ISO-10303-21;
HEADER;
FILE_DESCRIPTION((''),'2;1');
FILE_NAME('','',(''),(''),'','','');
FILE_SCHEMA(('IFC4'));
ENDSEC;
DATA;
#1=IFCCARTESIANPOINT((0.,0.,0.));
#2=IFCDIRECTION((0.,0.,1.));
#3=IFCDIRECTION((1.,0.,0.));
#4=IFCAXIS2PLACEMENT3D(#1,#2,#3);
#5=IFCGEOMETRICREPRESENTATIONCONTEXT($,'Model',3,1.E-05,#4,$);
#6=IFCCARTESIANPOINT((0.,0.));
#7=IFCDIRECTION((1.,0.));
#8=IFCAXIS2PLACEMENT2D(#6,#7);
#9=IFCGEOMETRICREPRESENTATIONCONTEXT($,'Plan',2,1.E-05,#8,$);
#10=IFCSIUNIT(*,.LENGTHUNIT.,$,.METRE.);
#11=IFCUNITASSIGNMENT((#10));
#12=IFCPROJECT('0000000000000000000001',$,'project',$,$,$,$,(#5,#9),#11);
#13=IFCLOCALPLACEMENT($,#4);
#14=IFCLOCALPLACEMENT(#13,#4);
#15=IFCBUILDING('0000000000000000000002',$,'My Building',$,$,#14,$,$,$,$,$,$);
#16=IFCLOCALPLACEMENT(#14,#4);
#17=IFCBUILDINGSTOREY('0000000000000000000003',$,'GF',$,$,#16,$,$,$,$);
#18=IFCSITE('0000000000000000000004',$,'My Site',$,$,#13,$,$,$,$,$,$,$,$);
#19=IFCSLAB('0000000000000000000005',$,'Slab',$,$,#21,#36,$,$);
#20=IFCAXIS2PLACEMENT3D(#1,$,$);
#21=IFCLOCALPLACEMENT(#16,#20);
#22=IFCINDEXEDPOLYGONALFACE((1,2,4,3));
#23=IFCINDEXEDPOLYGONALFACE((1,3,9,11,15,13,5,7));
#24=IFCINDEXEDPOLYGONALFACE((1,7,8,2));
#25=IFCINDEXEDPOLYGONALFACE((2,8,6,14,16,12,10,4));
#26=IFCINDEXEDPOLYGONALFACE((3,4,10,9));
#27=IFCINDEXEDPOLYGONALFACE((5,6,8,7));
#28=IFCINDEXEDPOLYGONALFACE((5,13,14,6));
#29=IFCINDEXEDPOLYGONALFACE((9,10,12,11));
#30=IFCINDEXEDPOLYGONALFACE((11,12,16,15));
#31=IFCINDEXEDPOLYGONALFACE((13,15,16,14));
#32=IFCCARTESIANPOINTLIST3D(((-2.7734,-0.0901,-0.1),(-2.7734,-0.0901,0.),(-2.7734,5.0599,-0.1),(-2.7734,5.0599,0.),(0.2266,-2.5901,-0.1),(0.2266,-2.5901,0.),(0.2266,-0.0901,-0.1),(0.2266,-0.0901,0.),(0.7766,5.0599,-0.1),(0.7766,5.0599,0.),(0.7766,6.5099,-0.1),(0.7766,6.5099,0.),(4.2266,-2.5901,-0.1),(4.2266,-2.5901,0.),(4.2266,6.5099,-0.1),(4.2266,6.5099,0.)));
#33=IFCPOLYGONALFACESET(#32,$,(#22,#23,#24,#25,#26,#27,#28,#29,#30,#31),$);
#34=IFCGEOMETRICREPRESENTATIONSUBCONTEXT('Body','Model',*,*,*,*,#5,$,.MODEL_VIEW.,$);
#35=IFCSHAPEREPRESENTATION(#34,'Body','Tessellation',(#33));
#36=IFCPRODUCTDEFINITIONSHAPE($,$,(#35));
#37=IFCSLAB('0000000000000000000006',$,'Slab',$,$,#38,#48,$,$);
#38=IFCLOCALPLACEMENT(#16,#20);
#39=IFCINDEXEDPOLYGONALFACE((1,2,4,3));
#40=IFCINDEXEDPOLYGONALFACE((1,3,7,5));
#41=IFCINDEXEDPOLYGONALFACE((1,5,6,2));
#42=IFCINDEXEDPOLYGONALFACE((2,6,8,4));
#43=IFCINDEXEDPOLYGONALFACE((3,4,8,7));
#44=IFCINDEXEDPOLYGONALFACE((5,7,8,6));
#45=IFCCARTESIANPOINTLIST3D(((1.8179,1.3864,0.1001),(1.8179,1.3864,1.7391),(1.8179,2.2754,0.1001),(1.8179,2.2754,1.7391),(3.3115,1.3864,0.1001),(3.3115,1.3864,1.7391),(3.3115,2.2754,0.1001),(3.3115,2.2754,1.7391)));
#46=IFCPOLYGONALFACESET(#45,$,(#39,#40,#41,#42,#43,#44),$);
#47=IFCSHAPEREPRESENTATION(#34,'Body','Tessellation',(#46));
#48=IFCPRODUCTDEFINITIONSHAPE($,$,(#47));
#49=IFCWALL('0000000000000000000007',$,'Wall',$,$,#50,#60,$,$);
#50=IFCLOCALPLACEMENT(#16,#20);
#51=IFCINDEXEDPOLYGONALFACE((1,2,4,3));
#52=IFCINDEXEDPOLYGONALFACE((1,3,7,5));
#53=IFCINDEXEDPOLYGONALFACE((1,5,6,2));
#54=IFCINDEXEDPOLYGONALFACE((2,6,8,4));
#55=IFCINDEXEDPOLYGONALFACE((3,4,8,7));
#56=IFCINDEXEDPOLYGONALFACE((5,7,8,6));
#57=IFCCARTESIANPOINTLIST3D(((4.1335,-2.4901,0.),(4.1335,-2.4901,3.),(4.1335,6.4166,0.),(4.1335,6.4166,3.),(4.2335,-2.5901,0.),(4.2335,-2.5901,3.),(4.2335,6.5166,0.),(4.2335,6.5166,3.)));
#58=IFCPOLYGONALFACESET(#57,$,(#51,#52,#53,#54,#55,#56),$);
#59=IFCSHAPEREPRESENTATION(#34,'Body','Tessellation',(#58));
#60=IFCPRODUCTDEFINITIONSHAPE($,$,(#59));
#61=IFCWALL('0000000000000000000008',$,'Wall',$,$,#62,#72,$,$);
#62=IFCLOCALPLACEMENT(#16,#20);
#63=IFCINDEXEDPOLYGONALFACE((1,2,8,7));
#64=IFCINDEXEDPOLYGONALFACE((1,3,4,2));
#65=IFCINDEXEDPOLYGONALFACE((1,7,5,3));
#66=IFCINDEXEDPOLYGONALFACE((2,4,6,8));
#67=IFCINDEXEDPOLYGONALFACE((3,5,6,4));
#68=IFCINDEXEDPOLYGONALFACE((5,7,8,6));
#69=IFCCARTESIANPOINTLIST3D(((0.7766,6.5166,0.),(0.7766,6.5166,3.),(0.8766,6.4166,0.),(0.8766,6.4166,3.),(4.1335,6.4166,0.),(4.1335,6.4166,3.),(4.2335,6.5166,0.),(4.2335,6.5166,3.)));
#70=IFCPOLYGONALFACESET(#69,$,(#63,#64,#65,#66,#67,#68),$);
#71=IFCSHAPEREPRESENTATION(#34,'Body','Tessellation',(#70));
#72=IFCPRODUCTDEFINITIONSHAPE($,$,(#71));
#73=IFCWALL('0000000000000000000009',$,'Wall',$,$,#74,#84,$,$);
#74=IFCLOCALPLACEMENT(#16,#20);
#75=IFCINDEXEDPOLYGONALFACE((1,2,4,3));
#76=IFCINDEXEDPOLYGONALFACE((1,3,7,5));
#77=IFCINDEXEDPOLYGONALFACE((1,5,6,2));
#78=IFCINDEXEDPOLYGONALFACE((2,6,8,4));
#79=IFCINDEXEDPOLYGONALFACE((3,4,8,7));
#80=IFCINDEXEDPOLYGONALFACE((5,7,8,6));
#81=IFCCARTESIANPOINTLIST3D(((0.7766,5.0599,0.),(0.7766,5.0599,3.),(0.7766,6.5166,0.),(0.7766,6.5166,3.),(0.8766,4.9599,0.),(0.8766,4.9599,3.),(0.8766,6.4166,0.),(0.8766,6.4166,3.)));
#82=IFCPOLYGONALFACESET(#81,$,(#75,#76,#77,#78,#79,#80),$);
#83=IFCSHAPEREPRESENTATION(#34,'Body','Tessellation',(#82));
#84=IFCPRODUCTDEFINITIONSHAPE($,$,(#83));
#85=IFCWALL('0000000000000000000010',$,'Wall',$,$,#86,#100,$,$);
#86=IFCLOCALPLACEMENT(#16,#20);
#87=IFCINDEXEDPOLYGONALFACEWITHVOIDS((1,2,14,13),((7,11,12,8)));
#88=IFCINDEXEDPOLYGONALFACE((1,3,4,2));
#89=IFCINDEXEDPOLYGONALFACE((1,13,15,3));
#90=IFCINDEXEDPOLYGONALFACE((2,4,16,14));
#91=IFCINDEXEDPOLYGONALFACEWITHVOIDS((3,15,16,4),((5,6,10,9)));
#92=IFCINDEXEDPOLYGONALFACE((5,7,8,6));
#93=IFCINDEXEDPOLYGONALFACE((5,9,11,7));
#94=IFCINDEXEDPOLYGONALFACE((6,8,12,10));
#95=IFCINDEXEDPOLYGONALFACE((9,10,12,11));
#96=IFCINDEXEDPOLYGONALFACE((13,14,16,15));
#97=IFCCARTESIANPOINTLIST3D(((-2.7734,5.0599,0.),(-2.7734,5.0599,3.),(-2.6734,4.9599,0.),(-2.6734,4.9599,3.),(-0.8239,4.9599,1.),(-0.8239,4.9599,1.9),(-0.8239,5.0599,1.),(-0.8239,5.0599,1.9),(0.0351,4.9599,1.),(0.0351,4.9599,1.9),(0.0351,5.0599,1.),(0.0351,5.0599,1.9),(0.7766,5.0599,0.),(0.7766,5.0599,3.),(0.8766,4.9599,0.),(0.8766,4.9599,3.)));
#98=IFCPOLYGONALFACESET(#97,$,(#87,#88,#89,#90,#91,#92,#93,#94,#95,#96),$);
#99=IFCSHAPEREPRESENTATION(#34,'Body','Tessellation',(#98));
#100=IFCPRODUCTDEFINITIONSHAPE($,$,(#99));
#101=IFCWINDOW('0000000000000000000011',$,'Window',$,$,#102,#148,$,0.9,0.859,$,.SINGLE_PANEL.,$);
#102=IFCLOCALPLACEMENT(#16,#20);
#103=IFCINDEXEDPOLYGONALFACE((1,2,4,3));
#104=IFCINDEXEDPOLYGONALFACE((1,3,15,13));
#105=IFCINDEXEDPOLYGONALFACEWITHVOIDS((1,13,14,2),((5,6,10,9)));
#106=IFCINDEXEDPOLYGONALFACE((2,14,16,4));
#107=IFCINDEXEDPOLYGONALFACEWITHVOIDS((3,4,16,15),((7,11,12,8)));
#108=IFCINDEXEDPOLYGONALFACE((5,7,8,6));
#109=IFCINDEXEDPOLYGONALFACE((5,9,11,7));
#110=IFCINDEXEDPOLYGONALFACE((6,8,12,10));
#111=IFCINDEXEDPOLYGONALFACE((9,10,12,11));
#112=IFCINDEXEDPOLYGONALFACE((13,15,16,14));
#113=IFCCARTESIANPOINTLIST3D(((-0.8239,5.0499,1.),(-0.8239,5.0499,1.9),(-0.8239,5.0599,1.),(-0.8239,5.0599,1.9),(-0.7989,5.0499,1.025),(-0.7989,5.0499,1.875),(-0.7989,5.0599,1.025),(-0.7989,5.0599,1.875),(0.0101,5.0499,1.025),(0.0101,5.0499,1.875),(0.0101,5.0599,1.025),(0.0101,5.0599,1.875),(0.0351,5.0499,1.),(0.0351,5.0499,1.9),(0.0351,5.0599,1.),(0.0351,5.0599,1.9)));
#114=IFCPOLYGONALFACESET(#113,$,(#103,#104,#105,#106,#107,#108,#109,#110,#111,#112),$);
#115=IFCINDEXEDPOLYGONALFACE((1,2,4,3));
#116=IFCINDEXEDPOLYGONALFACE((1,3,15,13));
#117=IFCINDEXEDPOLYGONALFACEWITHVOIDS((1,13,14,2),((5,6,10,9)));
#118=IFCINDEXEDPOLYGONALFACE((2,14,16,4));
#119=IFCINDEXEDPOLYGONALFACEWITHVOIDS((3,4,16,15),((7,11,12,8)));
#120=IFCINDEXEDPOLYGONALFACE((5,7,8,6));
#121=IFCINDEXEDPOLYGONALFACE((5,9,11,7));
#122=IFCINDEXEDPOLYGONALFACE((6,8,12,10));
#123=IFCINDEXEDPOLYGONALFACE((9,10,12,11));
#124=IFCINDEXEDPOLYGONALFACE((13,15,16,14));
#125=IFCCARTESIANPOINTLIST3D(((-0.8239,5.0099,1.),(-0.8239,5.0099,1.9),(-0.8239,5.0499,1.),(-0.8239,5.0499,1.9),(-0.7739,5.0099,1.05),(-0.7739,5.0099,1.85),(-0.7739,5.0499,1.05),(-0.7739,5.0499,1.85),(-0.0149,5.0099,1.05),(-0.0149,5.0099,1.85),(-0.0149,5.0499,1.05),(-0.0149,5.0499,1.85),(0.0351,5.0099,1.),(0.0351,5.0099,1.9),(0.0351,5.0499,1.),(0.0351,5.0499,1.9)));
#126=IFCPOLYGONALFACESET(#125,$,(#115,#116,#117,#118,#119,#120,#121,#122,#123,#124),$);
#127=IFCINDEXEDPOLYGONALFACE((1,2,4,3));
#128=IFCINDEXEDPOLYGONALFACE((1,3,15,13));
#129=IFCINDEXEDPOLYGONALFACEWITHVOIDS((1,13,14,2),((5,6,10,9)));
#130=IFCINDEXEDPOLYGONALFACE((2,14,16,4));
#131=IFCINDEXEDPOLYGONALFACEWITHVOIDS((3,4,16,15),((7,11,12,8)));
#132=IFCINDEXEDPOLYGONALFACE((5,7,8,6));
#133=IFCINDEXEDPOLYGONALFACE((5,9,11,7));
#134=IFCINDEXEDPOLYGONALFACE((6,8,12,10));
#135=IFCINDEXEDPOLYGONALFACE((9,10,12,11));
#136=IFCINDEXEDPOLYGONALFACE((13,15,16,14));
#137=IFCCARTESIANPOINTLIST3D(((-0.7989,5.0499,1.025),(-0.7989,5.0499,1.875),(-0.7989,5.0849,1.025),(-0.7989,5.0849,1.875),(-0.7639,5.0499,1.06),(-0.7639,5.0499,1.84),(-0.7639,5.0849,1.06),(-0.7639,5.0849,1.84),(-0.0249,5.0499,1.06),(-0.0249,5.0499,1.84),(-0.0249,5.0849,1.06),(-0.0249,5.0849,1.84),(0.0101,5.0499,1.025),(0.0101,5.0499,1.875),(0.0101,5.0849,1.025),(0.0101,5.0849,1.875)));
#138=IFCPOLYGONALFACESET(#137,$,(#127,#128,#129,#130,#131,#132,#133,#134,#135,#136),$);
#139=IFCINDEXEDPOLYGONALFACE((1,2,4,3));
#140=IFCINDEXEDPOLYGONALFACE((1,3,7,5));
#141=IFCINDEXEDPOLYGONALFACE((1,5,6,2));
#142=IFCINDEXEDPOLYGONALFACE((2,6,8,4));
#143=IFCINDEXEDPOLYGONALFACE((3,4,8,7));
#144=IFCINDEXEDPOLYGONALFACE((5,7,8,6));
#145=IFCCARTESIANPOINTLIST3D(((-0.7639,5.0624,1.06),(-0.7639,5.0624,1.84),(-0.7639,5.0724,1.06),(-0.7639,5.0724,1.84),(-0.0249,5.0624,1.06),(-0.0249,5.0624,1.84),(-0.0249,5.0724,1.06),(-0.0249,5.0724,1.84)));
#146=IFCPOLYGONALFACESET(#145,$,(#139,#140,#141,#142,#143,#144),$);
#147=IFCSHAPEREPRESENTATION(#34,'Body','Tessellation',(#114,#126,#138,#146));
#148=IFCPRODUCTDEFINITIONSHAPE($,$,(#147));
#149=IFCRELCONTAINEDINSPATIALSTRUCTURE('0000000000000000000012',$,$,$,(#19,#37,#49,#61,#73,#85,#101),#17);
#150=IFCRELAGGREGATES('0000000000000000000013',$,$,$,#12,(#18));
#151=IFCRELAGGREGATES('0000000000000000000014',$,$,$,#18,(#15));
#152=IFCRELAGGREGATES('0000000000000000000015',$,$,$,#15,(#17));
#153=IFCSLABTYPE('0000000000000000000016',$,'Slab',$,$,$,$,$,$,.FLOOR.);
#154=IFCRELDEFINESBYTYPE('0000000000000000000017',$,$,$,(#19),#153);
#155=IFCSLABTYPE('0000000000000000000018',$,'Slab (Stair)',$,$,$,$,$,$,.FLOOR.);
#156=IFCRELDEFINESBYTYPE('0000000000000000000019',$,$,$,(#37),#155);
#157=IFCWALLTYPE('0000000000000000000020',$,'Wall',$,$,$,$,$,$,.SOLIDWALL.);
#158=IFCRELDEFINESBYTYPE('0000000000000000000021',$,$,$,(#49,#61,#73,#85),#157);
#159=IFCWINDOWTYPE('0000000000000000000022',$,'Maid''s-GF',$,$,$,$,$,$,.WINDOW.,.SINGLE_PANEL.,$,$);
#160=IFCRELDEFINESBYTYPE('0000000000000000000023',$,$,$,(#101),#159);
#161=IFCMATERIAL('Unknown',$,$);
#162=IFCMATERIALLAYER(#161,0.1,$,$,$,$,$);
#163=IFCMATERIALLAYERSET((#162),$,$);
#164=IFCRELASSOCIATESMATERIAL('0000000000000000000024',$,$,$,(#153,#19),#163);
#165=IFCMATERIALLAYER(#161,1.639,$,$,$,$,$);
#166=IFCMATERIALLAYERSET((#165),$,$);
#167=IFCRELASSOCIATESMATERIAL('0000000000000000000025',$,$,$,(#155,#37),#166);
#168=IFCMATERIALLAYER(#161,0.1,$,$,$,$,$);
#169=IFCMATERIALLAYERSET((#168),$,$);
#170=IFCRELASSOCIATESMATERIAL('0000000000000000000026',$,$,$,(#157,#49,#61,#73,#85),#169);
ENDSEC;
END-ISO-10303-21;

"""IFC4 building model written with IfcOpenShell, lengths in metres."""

from ifc_helpers import new_model, entity, si_unit, frame, origin_with_axes, origin_2d_with_axis, place, context, subcontext, project, spatial, line, indexed_curve, outline, extrude, shape, source, transform, mapped, material, layer, layer_set, layer_usage, type_object, type_shapes, element, fill, save


model = new_model("IFC4")

# Units and contexts
model_context = context("Model", 3, precision=1e-05, world=origin_with_axes())
plan_context = context("Plan", 2, precision=1e-05, world=origin_2d_with_axis())
body_context_1 = subcontext(model_context, "Body", "Model", "MODEL_VIEW")
body_context_2 = subcontext(plan_context, "Body", "Plan", "PLAN_VIEW")
ifc_project = project(units=[si_unit("LENGTHUNIT", "METRE")], contexts=[model_context, plan_context])

# Site, building, storey
site_placement = place(None, origin_with_axes())
site = spatial("IfcSite", under=ifc_project, at=site_placement, Name="My Site")
building_placement = place(site_placement, origin_with_axes())
building = spatial("IfcBuilding", under=site, at=building_placement, Name="My Building")
storey_placement = place(building_placement, origin_with_axes())
storey = spatial("IfcBuildingStorey", under=building, at=storey_placement, Name="GF")

# Slabs
ifc_material_1 = material(Name="Unknown")
ifc_layer_1 = layer(ifc_material_1, 0.1)
ifc_layer_set_1 = layer_set([ifc_layer_1])
ifc_layer_usage_1 = layer_usage(ifc_layer_set_1, "AXIS3", "POSITIVE", -0.1)
slab_type_1 = type_object("IfcSlabType", Name="Slab", PredefinedType="FLOOR", material=ifc_layer_set_1)
slab_1_placement = place(storey_placement, frame((4.2266, -2.5901, 0.0), z_axis=(0.0, 0.0, 1.0), x_axis=(1.0, 0.0, 0.0)))
element("IfcSlab", 1, at=slab_1_placement, inside=storey, type_object=slab_type_1, material=ifc_layer_usage_1, Name="Slab", context=body_context_1, shape_type="SweptSolid", body=[
    extrude(outline(indexed_curve([(0.0, 0.0), (0.0, 9.1), (-3.45, 9.1), (-3.45, 7.65), (-7.0, 7.65), (-7.0, 2.5), (-4.0, 2.5), (-4.0, 0.0), (0.0, 0.0)])), frame((0.0, 0.0, -0.1), z_axis=(0.0, 0.0, 1.0), x_axis=(1.0, 0.0, 0.0)), (0.0, 0.0, 1.0), 0.1),
])
ifc_layer_2 = layer(ifc_material_1, 1.639)
ifc_layer_set_2 = layer_set([ifc_layer_2])
ifc_layer_usage_2 = layer_usage(ifc_layer_set_2, "AXIS3", "POSITIVE", -0.1)
slab_type_2 = type_object("IfcSlabType", Name="Slab (Stair)", PredefinedType="FLOOR", material=ifc_layer_set_2)
slab_2_placement = place(storey_placement, frame((3.3115, 2.2754, 0.2001), z_axis=(0.0, 0.0, 1.0), x_axis=(1.0, 0.0, 0.0)))
element("IfcSlab", 2, at=slab_2_placement, inside=storey, type_object=slab_type_2, material=ifc_layer_usage_2, Name="Slab", context=body_context_1, shape_type="SweptSolid", body=[
    extrude(outline(indexed_curve([(-1.4936, 0.0), (-1.4936, -0.8889), (0.0, -0.8889), (0.0, 0.0), (-1.4936, 0.0)])), frame((0.0, 0.0, -0.1), z_axis=(0.0, 0.0, 1.0), x_axis=(1.0, 0.0, 0.0)), (0.0, 0.0, 1.0), 1.639),
])

# Shared definitions
ifc_layer_3 = layer(ifc_material_1, 0.1)
ifc_layer_set_3 = layer_set([ifc_layer_3])
wall_type = type_object("IfcWallType", Name="Wall", PredefinedType="SOLIDWALL", material=ifc_layer_set_3)

# Walls
ifc_layer_usage_3 = layer_usage(ifc_layer_set_3, "AXIS2", "POSITIVE", 0.0)
wall_1_placement = place(storey_placement, frame((4.2335, -2.5901, 0.0), z_axis=(0.0, 0.0, 1.0), x_axis=(0.0, 1.0, 0.0)))
element("IfcWall", 3, at=wall_1_placement, inside=storey, type_object=wall_type, material=ifc_layer_usage_3, Name="Wall", context=body_context_1, shape_type="SweptSolid", body=[
    extrude(outline(indexed_curve([(0.0, 0.0), (0.1, 0.1), (9.0067, 0.1), (9.1067, 0.0)], segments=[line(1, 2, 3, 4, 1)])), origin_with_axes(), (0.0, 0.0, 1.0), 3.0),
])
ifc_layer_usage_4 = layer_usage(ifc_layer_set_3, "AXIS2", "POSITIVE", 0.0)
wall_2_placement = place(storey_placement, frame((4.2335, 6.5166, 0.0), z_axis=(0.0, 0.0, 1.0), x_axis=(-1.0, 0.0, 0.0)))
element("IfcWall", 4, at=wall_2_placement, inside=storey, type_object=wall_type, material=ifc_layer_usage_4, Name="Wall", context=body_context_1, shape_type="SweptSolid", body=[
    extrude(outline(indexed_curve([(0.0, 0.0), (0.1, 0.1), (3.3569, 0.1), (3.4569, 0.0)], segments=[line(1, 2, 3, 4, 1)])), origin_with_axes(), (0.0, 0.0, 1.0), 3.0),
])
ifc_layer_usage_5 = layer_usage(ifc_layer_set_3, "AXIS2", "POSITIVE", 0.0)
wall_3_placement = place(storey_placement, frame((0.7766, 6.5166, 0.0), z_axis=(0.0, 0.0, 1.0), x_axis=(0.0, -1.0, 0.0)))
element("IfcWall", 5, at=wall_3_placement, inside=storey, type_object=wall_type, material=ifc_layer_usage_5, Name="Wall", context=body_context_1, shape_type="SweptSolid", body=[
    extrude(outline(indexed_curve([(0.0, 0.0), (0.1, 0.1), (1.5567, 0.1), (1.4567, 0.0)], segments=[line(1, 2, 3, 4, 1)])), origin_with_axes(), (0.0, 0.0, 1.0), 3.0),
])

# Wall, opening, window
ifc_layer_usage_6 = layer_usage(ifc_layer_set_3, "AXIS2", "POSITIVE", 0.0)
wall_4_placement = place(storey_placement, frame((0.7766, 5.0599, 0.0), z_axis=(0.0, 0.0, 1.0), x_axis=(-1.0, 0.0, 0.0)))
wall_4 = element("IfcWall", 6, at=wall_4_placement, inside=storey, type_object=wall_type, material=ifc_layer_usage_6, Name="Wall", context=body_context_1, shape_type="SweptSolid", body=[
    extrude(outline(indexed_curve([(0.0, 0.0), (-0.1, 0.1), (3.45, 0.1), (3.55, 0.0)], segments=[line(1, 2, 3, 4, 1)])), origin_with_axes(), (0.0, 0.0, 1.0), 3.0),
])
shared_shape_1 = source(origin_with_axes(), body_context_1, "Body", "SweptSolid", [
    extrude(outline(indexed_curve([(0.0, 0.0), (0.859, 0.0), (0.859, 0.9), (0.0, 0.9)], segments=[line(1, 2, 3, 4, 1)])), frame((0.0, -0.6, 0.0), z_axis=(0.0, -1.0, 0.0), x_axis=(1.0, 0.0, 0.0)), (0.0, 0.0, -1.0), 1.2),
])
opening_1_placement = place(wall_4_placement, frame((1.6005, 0.1, 1.0), z_axis=(0.0, 0.0, 1.0), x_axis=(-1.0, 0.000001, 0.0)))
opening_1 = element("IfcOpeningElement", 7, at=opening_1_placement, cuts=wall_4, PredefinedType="OPENING", context=body_context_1, shape_type="MappedRepresentation", body=[
    mapped(shared_shape_1, transform((0.0, 0.0, 0.0), x_axis=(1.0, 0.0, 0.0), y_axis=(0.0, 1.0, 0.0), z_axis=(0.0, 0.0, 1.0), scale=1.0)),
])
window_type_1 = type_object("IfcWindowType", Name="Maid's-GF", PartitioningType="SINGLE_PANEL", PredefinedType="WINDOW")
shared_shape_2 = source(origin_with_axes(), body_context_1, "Body", "SweptSolid", [
    extrude(outline(indexed_curve([(0.0, 0.0), (0.859, 0.0), (0.859, 0.9), (0.0, 0.9)], segments=[line(1, 2, 3, 4, 1)]), holes=[indexed_curve([(0.025, 0.025), (0.834, 0.025), (0.834, 0.875), (0.025, 0.875)], segments=[line(1, 2, 3, 4, 1)])]), frame((0.0, 0.09, 0.0), z_axis=(0.0, -1.0, 0.0), x_axis=(1.0, 0.0, 0.0)), (0.0, 0.0, -1.0), 0.01),
    extrude(outline(indexed_curve([(0.0, 0.0), (0.859, 0.0), (0.859, 0.9), (0.0, 0.9)], segments=[line(1, 2, 3, 4, 1)]), holes=[indexed_curve([(0.05, 0.05), (0.809, 0.05), (0.809, 0.85), (0.05, 0.85)], segments=[line(1, 2, 3, 4, 1)])]), frame((0.0, 0.05, 0.0), z_axis=(0.0, -1.0, 0.0), x_axis=(1.0, 0.0, 0.0)), (0.0, 0.0, -1.0), 0.04),
    extrude(outline(indexed_curve([(0.0, 0.0), (0.809, 0.0), (0.809, 0.85), (0.0, 0.85)], segments=[line(1, 2, 3, 4, 1)]), holes=[indexed_curve([(0.035, 0.035), (0.774, 0.035), (0.774, 0.815), (0.035, 0.815)], segments=[line(1, 2, 3, 4, 1)])]), frame((0.025, 0.09, 0.025), z_axis=(0.0, -1.0, 0.0), x_axis=(1.0, 0.0, 0.0)), (0.0, 0.0, -1.0), 0.035),
    extrude(outline(indexed_curve([(0.035, 0.035), (0.774, 0.035), (0.774, 0.815), (0.035, 0.815)], segments=[line(1, 2, 3, 4, 1)])), frame((0.025, 0.1025, 0.025), z_axis=(0.0, -1.0, 0.0), x_axis=(1.0, 0.0, 0.0)), (0.0, 0.0, -1.0), 0.01),
])
shared_shape_3 = source(origin_with_axes(), body_context_2, "Body", "Curve2D", [
    entity("IfcIndexedPolyCurve", entity("IfcCartesianPointList2D", [[0.05, 0.05], [0.809, 0.05]])),
    entity("IfcIndexedPolyCurve", entity("IfcCartesianPointList2D", [[0.0, 0.1], [0.025, 0.1], [0.025, 0.09], [0.05, 0.09], [0.05, 0.05], [0.0, 0.05]]), [entity("IfcLineIndex", [1, 2, 3, 4, 5, 6, 1])]),
    entity("IfcIndexedPolyCurve", entity("IfcCartesianPointList2D", [[0.859, 0.1], [0.834, 0.1], [0.834, 0.09], [0.809, 0.09], [0.809, 0.05], [0.859, 0.05]]), [entity("IfcLineIndex", [1, 2, 3, 4, 5, 6, 1])]),
    entity("IfcIndexedPolyCurve", entity("IfcCartesianPointList2D", [[0.025, 0.09], [0.06, 0.09], [0.06, 0.125], [0.025, 0.125]]), [entity("IfcLineIndex", [1, 2, 3, 4, 1])]),
    entity("IfcIndexedPolyCurve", entity("IfcCartesianPointList2D", [[0.834, 0.09], [0.799, 0.09], [0.799, 0.125], [0.834, 0.125]]), [entity("IfcLineIndex", [1, 2, 3, 4, 1])]),
    entity("IfcIndexedPolyCurve", entity("IfcCartesianPointList2D", [[0.06, 0.09], [0.799, 0.09]])),
    entity("IfcIndexedPolyCurve", entity("IfcCartesianPointList2D", [[0.06, 0.125], [0.799, 0.125]])),
    entity("IfcIndexedPolyCurve", entity("IfcCartesianPointList2D", [[0.06, 0.1075], [0.799, 0.1075]])),
])
type_shapes(window_type_1, [shared_shape_2, shared_shape_3])
window_1_placement = place(opening_1_placement, frame((0.0, 0.0, 0.0), z_axis=(0.0, 0.0, 1.0), x_axis=(1.0, 0.0, 0.0)))
window_1 = element("IfcWindow", 8, at=window_1_placement, inside=storey, type_object=window_type_1, Name="Window", OverallHeight=0.9, OverallWidth=0.859, PartitioningType="SINGLE_PANEL", shapes=[
    shape(body_context_1, "Body", "MappedRepresentation", [mapped(shared_shape_2, transform((0.0, 0.0, 0.0), x_axis=(1.0, 0.0, 0.0), y_axis=(0.0, 1.0, 0.0), z_axis=(0.0, 0.0, 1.0), scale=1.0))]),
    shape(body_context_2, "Body", "MappedRepresentation", [mapped(shared_shape_3, transform((0.0, 0.0, 0.0), x_axis=(1.0, 0.0, 0.0), y_axis=(0.0, 1.0, 0.0), z_axis=(0.0, 0.0, 1.0), scale=1.0))]),
])
fill(opening_1, window_1)

save(model, "model.ifc")
